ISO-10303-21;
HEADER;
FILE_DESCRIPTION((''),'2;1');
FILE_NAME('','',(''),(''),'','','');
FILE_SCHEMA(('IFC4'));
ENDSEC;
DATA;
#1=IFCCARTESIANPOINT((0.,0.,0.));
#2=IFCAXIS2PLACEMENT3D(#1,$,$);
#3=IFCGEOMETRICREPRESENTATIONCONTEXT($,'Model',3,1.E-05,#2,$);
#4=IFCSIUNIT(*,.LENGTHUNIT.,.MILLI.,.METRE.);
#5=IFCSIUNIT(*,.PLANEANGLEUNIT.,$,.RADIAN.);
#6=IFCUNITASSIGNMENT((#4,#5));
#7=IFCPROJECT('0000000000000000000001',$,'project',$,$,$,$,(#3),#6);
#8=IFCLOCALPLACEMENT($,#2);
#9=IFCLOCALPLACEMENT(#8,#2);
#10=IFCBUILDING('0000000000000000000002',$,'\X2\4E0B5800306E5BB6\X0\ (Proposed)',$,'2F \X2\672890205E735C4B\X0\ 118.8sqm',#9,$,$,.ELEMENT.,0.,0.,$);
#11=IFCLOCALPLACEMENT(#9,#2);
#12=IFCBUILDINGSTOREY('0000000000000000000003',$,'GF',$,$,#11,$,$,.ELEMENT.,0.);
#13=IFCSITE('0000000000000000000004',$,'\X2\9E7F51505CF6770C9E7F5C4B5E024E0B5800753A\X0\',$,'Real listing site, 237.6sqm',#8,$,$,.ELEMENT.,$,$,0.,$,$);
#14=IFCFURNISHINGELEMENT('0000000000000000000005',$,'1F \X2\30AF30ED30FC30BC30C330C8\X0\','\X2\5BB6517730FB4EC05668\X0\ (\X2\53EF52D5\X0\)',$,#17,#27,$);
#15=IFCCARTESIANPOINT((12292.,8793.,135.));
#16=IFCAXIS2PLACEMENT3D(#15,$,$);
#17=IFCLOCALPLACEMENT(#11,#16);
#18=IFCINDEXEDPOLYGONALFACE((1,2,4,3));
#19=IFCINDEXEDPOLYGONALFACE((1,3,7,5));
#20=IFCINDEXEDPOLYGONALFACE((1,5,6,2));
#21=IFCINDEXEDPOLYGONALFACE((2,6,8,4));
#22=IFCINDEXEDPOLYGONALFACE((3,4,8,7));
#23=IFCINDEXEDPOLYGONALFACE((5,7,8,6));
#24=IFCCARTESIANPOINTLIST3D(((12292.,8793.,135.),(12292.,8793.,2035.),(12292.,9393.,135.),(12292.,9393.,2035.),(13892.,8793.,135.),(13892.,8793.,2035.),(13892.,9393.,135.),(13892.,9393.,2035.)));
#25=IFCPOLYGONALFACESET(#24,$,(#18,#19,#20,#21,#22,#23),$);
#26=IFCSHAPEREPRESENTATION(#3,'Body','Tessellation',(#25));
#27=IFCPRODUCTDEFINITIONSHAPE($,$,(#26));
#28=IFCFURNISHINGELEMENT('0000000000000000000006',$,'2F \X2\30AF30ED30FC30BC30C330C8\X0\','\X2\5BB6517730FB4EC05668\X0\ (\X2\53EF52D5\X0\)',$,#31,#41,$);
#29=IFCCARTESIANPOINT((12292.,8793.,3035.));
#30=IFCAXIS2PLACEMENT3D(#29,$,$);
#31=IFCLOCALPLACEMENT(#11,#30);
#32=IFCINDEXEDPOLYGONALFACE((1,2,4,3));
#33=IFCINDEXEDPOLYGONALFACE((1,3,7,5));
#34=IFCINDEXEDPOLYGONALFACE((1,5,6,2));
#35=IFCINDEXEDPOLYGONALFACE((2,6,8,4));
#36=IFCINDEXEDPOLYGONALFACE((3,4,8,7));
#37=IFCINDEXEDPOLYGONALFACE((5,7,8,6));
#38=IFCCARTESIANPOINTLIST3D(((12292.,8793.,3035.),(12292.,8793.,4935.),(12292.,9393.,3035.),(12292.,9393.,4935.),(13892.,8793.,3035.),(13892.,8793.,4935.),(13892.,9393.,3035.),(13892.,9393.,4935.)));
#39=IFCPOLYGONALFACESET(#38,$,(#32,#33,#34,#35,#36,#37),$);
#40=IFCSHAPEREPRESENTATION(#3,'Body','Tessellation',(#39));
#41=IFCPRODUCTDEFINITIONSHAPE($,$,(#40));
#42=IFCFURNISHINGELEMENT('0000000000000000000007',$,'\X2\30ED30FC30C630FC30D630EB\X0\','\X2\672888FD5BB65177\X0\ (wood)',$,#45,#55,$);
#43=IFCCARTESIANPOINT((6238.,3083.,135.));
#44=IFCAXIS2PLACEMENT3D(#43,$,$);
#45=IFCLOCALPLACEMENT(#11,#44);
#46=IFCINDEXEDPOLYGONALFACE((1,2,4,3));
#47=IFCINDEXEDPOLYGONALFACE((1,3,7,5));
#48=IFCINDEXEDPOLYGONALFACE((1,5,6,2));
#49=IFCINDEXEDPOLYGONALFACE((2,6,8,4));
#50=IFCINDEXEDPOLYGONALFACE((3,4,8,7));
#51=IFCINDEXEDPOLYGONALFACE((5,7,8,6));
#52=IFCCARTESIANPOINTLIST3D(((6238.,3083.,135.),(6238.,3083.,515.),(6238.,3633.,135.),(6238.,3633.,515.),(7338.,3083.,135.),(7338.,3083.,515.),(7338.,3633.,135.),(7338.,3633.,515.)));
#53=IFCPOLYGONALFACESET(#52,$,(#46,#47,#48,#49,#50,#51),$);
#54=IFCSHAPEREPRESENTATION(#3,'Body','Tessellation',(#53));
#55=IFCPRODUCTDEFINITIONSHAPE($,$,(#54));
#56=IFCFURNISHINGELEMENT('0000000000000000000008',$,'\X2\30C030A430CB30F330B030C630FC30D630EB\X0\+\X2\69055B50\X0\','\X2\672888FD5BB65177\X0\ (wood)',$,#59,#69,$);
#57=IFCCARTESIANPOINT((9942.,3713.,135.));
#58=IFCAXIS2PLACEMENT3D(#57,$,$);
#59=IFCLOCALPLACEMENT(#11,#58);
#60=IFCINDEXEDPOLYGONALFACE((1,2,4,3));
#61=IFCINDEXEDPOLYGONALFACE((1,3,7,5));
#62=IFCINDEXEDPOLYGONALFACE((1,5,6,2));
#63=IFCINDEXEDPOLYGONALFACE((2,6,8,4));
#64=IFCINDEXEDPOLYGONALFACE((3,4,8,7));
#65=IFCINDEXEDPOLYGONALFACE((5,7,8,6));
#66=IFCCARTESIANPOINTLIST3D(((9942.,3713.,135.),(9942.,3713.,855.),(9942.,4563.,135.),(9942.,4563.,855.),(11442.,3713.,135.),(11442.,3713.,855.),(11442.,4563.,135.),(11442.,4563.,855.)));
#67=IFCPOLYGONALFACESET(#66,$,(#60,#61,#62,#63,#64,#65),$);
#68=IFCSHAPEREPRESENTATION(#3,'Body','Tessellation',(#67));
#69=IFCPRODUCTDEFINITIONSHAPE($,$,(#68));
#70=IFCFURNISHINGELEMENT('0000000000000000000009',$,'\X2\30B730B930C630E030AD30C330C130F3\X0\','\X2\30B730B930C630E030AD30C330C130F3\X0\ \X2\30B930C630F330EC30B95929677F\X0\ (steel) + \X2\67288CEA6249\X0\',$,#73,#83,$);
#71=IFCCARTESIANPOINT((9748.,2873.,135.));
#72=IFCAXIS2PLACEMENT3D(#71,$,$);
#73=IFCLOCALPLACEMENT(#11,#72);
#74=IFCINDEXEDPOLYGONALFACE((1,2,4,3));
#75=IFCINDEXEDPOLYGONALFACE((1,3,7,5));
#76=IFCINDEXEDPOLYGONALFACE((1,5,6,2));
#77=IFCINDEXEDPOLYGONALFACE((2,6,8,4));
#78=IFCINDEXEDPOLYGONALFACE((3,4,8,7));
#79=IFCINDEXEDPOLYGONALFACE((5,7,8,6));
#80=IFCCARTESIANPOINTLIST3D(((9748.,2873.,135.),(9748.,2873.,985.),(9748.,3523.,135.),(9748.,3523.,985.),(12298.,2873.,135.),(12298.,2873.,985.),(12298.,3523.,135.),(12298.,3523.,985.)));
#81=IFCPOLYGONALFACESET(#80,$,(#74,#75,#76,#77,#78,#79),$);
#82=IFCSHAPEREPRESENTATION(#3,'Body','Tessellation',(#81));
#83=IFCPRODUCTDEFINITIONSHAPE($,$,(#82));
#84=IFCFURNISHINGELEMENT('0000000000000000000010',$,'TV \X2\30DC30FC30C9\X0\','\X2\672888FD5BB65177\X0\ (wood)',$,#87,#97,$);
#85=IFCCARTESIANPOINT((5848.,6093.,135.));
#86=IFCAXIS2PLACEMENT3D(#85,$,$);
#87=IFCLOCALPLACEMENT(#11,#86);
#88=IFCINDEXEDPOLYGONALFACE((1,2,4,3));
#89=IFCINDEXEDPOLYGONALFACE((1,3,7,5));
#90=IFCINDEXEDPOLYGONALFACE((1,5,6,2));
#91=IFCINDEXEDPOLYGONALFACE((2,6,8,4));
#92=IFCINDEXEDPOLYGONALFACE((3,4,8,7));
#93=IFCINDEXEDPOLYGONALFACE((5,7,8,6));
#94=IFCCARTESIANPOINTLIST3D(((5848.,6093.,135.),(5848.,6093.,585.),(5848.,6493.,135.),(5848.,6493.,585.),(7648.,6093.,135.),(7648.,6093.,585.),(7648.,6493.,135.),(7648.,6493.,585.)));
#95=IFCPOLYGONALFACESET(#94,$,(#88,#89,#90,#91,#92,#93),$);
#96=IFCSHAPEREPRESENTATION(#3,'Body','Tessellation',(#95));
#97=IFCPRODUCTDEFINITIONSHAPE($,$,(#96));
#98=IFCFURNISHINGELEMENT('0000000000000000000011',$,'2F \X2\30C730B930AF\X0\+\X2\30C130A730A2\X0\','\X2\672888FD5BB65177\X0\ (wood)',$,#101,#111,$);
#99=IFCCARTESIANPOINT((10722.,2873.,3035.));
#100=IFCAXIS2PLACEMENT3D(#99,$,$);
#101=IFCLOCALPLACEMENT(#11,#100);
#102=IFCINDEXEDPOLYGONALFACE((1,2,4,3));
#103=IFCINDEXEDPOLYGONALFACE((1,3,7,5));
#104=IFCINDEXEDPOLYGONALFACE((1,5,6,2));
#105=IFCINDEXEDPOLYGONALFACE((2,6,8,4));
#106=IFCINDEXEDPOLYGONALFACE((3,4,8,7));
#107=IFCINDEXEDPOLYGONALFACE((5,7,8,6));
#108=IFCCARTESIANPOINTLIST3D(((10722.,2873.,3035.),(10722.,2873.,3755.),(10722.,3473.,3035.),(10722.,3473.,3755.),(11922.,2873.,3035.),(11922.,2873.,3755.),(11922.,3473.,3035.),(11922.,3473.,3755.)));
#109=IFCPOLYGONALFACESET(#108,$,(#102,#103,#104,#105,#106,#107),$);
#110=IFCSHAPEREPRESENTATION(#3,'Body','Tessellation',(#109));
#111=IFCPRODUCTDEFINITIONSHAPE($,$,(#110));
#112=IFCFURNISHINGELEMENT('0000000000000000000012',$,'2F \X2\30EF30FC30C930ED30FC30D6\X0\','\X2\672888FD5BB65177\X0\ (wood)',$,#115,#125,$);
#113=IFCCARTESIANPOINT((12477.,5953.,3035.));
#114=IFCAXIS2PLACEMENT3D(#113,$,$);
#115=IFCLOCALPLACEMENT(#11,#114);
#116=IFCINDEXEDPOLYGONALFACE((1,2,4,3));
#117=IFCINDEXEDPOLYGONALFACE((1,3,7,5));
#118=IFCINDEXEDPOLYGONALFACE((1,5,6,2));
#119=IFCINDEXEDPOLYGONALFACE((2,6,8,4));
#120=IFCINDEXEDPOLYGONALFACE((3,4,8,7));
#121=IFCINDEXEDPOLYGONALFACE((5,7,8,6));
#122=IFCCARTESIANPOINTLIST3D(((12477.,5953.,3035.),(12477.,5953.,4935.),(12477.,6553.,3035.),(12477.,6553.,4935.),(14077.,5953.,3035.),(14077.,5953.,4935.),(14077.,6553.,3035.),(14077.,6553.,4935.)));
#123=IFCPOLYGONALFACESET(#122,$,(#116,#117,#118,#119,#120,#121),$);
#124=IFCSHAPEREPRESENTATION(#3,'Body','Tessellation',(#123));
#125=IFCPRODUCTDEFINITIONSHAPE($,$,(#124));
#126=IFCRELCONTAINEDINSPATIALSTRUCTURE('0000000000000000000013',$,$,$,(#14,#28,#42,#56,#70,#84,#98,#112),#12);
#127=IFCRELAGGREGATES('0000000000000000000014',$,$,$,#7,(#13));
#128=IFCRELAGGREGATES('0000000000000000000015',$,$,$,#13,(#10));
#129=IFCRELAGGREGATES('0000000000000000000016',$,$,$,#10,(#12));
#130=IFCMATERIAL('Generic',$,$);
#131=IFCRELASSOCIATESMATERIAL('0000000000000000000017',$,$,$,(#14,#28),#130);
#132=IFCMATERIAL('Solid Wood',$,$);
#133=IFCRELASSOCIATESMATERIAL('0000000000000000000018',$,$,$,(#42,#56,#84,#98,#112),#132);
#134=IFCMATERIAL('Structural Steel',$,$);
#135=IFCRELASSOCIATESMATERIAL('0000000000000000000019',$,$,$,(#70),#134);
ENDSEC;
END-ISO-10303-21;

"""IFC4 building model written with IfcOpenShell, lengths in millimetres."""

from ifc_helpers import new_model, si_unit, frame, frame_2d, origin, place, context, project, spatial, rectangle, extrude, material, element, save


model = new_model("IFC4")

# Units and contexts
model_context = context("Model", 3, precision=1e-05, world=origin())
ifc_project = project(units=[si_unit("LENGTHUNIT", "METRE", prefix="MILLI"), si_unit("PLANEANGLEUNIT", "RADIAN")], contexts=[model_context])

# Site, building, storey
site_placement = place(None, origin())
site = spatial("IfcSite", under=ifc_project, at=site_placement, Name="鹿児島県鹿屋市下堀町", ObjectType="Real listing site, 237.6sqm", CompositionType="ELEMENT", RefElevation=0.0)
building_placement = place(site_placement, origin())
building = spatial("IfcBuilding", under=site, at=building_placement, Name="下堀の家 (Proposed)", ObjectType="2F 木造平屋 118.8sqm", CompositionType="ELEMENT", ElevationOfRefHeight=0.0, ElevationOfTerrain=0.0)
storey_placement = place(building_placement, origin())
storey = spatial("IfcBuildingStorey", under=building, at=storey_placement, Name="GF", CompositionType="ELEMENT", Elevation=0.0)

# Shared definitions
ifc_material_1 = material(Name="Solid Wood")

# Shared definitions
ifc_material_2 = material(Name="Generic")

# Furnishing elements
furnishing_1_placement = place(storey_placement, frame((12292.0, 8793.0, 135.0)))
element("IfcFurnishingElement", 1, at=furnishing_1_placement, inside=storey, material=ifc_material_2, Name="1F クローゼット", Description="家具・什器 (可動)", context=model_context, shape_type="SweptSolid", body=[
    extrude(rectangle(XDim=1600.0, YDim=600.0, at=frame_2d((800.0, 300.0))), frame((12292.0, 8793.0, 135.0)), (0.0, 0.0, 1.0), 1900.0),
])
furnishing_2_placement = place(storey_placement, frame((12292.0, 8793.0, 3035.0)))
element("IfcFurnishingElement", 2, at=furnishing_2_placement, inside=storey, material=ifc_material_2, Name="2F クローゼット", Description="家具・什器 (可動)", context=model_context, shape_type="SweptSolid", body=[
    extrude(rectangle(XDim=1600.0, YDim=600.0, at=frame_2d((800.0, 300.0))), frame((12292.0, 8793.0, 3035.0)), (0.0, 0.0, 1.0), 1900.0),
])
furnishing_3_placement = place(storey_placement, frame((6238.0, 3083.0, 135.0)))
element("IfcFurnishingElement", 3, at=furnishing_3_placement, inside=storey, material=ifc_material_1, Name="ローテーブル", Description="木製家具 (wood)", context=model_context, shape_type="SweptSolid", body=[
    extrude(rectangle(XDim=1100.0, YDim=550.0, at=frame_2d((550.0, 275.0))), frame((6238.0, 3083.0, 135.0)), (0.0, 0.0, 1.0), 380.0),
])
furnishing_4_placement = place(storey_placement, frame((9942.0, 3713.0, 135.0)))
element("IfcFurnishingElement", 4, at=furnishing_4_placement, inside=storey, material=ifc_material_1, Name="ダイニングテーブル+椅子", Description="木製家具 (wood)", context=model_context, shape_type="SweptSolid", body=[
    extrude(rectangle(XDim=1500.0, YDim=850.0, at=frame_2d((750.0, 425.0))), frame((9942.0, 3713.0, 135.0)), (0.0, 0.0, 1.0), 720.0),
])
ifc_material_3 = material(Name="Structural Steel")
furnishing_5_placement = place(storey_placement, frame((9748.0, 2873.0, 135.0)))
element("IfcFurnishingElement", 5, at=furnishing_5_placement, inside=storey, material=ifc_material_3, Name="システムキッチン", Description="システムキッチン ステンレス天板 (steel) + 木質扉", context=model_context, shape_type="SweptSolid", body=[
    extrude(rectangle(XDim=2550.0, YDim=650.0, at=frame_2d((1275.0, 325.0))), frame((9748.0, 2873.0, 135.0)), (0.0, 0.0, 1.0), 850.0),
])
furnishing_6_placement = place(storey_placement, frame((5848.0, 6093.0, 135.0)))
element("IfcFurnishingElement", 6, at=furnishing_6_placement, inside=storey, material=ifc_material_1, Name="TV ボード", Description="木製家具 (wood)", context=model_context, shape_type="SweptSolid", body=[
    extrude(rectangle(XDim=1800.0, YDim=400.0, at=frame_2d((900.0, 200.0))), frame((5848.0, 6093.0, 135.0)), (0.0, 0.0, 1.0), 450.0),
])
furnishing_7_placement = place(storey_placement, frame((10722.0, 2873.0, 3035.0)))
element("IfcFurnishingElement", 7, at=furnishing_7_placement, inside=storey, material=ifc_material_1, Name="2F デスク+チェア", Description="木製家具 (wood)", context=model_context, shape_type="SweptSolid", body=[
    extrude(rectangle(XDim=1200.0, YDim=600.0, at=frame_2d((600.0, 300.0))), frame((10722.0, 2873.0, 3035.0)), (0.0, 0.0, 1.0), 720.0),
])
furnishing_8_placement = place(storey_placement, frame((12477.0, 5953.0, 3035.0)))
element("IfcFurnishingElement", 8, at=furnishing_8_placement, inside=storey, material=ifc_material_1, Name="2F ワードローブ", Description="木製家具 (wood)", context=model_context, shape_type="SweptSolid", body=[
    extrude(rectangle(XDim=1600.0, YDim=600.0, at=frame_2d((800.0, 300.0))), frame((12477.0, 5953.0, 3035.0)), (0.0, 0.0, 1.0), 1900.0),
])

save(model, "model.ifc")
